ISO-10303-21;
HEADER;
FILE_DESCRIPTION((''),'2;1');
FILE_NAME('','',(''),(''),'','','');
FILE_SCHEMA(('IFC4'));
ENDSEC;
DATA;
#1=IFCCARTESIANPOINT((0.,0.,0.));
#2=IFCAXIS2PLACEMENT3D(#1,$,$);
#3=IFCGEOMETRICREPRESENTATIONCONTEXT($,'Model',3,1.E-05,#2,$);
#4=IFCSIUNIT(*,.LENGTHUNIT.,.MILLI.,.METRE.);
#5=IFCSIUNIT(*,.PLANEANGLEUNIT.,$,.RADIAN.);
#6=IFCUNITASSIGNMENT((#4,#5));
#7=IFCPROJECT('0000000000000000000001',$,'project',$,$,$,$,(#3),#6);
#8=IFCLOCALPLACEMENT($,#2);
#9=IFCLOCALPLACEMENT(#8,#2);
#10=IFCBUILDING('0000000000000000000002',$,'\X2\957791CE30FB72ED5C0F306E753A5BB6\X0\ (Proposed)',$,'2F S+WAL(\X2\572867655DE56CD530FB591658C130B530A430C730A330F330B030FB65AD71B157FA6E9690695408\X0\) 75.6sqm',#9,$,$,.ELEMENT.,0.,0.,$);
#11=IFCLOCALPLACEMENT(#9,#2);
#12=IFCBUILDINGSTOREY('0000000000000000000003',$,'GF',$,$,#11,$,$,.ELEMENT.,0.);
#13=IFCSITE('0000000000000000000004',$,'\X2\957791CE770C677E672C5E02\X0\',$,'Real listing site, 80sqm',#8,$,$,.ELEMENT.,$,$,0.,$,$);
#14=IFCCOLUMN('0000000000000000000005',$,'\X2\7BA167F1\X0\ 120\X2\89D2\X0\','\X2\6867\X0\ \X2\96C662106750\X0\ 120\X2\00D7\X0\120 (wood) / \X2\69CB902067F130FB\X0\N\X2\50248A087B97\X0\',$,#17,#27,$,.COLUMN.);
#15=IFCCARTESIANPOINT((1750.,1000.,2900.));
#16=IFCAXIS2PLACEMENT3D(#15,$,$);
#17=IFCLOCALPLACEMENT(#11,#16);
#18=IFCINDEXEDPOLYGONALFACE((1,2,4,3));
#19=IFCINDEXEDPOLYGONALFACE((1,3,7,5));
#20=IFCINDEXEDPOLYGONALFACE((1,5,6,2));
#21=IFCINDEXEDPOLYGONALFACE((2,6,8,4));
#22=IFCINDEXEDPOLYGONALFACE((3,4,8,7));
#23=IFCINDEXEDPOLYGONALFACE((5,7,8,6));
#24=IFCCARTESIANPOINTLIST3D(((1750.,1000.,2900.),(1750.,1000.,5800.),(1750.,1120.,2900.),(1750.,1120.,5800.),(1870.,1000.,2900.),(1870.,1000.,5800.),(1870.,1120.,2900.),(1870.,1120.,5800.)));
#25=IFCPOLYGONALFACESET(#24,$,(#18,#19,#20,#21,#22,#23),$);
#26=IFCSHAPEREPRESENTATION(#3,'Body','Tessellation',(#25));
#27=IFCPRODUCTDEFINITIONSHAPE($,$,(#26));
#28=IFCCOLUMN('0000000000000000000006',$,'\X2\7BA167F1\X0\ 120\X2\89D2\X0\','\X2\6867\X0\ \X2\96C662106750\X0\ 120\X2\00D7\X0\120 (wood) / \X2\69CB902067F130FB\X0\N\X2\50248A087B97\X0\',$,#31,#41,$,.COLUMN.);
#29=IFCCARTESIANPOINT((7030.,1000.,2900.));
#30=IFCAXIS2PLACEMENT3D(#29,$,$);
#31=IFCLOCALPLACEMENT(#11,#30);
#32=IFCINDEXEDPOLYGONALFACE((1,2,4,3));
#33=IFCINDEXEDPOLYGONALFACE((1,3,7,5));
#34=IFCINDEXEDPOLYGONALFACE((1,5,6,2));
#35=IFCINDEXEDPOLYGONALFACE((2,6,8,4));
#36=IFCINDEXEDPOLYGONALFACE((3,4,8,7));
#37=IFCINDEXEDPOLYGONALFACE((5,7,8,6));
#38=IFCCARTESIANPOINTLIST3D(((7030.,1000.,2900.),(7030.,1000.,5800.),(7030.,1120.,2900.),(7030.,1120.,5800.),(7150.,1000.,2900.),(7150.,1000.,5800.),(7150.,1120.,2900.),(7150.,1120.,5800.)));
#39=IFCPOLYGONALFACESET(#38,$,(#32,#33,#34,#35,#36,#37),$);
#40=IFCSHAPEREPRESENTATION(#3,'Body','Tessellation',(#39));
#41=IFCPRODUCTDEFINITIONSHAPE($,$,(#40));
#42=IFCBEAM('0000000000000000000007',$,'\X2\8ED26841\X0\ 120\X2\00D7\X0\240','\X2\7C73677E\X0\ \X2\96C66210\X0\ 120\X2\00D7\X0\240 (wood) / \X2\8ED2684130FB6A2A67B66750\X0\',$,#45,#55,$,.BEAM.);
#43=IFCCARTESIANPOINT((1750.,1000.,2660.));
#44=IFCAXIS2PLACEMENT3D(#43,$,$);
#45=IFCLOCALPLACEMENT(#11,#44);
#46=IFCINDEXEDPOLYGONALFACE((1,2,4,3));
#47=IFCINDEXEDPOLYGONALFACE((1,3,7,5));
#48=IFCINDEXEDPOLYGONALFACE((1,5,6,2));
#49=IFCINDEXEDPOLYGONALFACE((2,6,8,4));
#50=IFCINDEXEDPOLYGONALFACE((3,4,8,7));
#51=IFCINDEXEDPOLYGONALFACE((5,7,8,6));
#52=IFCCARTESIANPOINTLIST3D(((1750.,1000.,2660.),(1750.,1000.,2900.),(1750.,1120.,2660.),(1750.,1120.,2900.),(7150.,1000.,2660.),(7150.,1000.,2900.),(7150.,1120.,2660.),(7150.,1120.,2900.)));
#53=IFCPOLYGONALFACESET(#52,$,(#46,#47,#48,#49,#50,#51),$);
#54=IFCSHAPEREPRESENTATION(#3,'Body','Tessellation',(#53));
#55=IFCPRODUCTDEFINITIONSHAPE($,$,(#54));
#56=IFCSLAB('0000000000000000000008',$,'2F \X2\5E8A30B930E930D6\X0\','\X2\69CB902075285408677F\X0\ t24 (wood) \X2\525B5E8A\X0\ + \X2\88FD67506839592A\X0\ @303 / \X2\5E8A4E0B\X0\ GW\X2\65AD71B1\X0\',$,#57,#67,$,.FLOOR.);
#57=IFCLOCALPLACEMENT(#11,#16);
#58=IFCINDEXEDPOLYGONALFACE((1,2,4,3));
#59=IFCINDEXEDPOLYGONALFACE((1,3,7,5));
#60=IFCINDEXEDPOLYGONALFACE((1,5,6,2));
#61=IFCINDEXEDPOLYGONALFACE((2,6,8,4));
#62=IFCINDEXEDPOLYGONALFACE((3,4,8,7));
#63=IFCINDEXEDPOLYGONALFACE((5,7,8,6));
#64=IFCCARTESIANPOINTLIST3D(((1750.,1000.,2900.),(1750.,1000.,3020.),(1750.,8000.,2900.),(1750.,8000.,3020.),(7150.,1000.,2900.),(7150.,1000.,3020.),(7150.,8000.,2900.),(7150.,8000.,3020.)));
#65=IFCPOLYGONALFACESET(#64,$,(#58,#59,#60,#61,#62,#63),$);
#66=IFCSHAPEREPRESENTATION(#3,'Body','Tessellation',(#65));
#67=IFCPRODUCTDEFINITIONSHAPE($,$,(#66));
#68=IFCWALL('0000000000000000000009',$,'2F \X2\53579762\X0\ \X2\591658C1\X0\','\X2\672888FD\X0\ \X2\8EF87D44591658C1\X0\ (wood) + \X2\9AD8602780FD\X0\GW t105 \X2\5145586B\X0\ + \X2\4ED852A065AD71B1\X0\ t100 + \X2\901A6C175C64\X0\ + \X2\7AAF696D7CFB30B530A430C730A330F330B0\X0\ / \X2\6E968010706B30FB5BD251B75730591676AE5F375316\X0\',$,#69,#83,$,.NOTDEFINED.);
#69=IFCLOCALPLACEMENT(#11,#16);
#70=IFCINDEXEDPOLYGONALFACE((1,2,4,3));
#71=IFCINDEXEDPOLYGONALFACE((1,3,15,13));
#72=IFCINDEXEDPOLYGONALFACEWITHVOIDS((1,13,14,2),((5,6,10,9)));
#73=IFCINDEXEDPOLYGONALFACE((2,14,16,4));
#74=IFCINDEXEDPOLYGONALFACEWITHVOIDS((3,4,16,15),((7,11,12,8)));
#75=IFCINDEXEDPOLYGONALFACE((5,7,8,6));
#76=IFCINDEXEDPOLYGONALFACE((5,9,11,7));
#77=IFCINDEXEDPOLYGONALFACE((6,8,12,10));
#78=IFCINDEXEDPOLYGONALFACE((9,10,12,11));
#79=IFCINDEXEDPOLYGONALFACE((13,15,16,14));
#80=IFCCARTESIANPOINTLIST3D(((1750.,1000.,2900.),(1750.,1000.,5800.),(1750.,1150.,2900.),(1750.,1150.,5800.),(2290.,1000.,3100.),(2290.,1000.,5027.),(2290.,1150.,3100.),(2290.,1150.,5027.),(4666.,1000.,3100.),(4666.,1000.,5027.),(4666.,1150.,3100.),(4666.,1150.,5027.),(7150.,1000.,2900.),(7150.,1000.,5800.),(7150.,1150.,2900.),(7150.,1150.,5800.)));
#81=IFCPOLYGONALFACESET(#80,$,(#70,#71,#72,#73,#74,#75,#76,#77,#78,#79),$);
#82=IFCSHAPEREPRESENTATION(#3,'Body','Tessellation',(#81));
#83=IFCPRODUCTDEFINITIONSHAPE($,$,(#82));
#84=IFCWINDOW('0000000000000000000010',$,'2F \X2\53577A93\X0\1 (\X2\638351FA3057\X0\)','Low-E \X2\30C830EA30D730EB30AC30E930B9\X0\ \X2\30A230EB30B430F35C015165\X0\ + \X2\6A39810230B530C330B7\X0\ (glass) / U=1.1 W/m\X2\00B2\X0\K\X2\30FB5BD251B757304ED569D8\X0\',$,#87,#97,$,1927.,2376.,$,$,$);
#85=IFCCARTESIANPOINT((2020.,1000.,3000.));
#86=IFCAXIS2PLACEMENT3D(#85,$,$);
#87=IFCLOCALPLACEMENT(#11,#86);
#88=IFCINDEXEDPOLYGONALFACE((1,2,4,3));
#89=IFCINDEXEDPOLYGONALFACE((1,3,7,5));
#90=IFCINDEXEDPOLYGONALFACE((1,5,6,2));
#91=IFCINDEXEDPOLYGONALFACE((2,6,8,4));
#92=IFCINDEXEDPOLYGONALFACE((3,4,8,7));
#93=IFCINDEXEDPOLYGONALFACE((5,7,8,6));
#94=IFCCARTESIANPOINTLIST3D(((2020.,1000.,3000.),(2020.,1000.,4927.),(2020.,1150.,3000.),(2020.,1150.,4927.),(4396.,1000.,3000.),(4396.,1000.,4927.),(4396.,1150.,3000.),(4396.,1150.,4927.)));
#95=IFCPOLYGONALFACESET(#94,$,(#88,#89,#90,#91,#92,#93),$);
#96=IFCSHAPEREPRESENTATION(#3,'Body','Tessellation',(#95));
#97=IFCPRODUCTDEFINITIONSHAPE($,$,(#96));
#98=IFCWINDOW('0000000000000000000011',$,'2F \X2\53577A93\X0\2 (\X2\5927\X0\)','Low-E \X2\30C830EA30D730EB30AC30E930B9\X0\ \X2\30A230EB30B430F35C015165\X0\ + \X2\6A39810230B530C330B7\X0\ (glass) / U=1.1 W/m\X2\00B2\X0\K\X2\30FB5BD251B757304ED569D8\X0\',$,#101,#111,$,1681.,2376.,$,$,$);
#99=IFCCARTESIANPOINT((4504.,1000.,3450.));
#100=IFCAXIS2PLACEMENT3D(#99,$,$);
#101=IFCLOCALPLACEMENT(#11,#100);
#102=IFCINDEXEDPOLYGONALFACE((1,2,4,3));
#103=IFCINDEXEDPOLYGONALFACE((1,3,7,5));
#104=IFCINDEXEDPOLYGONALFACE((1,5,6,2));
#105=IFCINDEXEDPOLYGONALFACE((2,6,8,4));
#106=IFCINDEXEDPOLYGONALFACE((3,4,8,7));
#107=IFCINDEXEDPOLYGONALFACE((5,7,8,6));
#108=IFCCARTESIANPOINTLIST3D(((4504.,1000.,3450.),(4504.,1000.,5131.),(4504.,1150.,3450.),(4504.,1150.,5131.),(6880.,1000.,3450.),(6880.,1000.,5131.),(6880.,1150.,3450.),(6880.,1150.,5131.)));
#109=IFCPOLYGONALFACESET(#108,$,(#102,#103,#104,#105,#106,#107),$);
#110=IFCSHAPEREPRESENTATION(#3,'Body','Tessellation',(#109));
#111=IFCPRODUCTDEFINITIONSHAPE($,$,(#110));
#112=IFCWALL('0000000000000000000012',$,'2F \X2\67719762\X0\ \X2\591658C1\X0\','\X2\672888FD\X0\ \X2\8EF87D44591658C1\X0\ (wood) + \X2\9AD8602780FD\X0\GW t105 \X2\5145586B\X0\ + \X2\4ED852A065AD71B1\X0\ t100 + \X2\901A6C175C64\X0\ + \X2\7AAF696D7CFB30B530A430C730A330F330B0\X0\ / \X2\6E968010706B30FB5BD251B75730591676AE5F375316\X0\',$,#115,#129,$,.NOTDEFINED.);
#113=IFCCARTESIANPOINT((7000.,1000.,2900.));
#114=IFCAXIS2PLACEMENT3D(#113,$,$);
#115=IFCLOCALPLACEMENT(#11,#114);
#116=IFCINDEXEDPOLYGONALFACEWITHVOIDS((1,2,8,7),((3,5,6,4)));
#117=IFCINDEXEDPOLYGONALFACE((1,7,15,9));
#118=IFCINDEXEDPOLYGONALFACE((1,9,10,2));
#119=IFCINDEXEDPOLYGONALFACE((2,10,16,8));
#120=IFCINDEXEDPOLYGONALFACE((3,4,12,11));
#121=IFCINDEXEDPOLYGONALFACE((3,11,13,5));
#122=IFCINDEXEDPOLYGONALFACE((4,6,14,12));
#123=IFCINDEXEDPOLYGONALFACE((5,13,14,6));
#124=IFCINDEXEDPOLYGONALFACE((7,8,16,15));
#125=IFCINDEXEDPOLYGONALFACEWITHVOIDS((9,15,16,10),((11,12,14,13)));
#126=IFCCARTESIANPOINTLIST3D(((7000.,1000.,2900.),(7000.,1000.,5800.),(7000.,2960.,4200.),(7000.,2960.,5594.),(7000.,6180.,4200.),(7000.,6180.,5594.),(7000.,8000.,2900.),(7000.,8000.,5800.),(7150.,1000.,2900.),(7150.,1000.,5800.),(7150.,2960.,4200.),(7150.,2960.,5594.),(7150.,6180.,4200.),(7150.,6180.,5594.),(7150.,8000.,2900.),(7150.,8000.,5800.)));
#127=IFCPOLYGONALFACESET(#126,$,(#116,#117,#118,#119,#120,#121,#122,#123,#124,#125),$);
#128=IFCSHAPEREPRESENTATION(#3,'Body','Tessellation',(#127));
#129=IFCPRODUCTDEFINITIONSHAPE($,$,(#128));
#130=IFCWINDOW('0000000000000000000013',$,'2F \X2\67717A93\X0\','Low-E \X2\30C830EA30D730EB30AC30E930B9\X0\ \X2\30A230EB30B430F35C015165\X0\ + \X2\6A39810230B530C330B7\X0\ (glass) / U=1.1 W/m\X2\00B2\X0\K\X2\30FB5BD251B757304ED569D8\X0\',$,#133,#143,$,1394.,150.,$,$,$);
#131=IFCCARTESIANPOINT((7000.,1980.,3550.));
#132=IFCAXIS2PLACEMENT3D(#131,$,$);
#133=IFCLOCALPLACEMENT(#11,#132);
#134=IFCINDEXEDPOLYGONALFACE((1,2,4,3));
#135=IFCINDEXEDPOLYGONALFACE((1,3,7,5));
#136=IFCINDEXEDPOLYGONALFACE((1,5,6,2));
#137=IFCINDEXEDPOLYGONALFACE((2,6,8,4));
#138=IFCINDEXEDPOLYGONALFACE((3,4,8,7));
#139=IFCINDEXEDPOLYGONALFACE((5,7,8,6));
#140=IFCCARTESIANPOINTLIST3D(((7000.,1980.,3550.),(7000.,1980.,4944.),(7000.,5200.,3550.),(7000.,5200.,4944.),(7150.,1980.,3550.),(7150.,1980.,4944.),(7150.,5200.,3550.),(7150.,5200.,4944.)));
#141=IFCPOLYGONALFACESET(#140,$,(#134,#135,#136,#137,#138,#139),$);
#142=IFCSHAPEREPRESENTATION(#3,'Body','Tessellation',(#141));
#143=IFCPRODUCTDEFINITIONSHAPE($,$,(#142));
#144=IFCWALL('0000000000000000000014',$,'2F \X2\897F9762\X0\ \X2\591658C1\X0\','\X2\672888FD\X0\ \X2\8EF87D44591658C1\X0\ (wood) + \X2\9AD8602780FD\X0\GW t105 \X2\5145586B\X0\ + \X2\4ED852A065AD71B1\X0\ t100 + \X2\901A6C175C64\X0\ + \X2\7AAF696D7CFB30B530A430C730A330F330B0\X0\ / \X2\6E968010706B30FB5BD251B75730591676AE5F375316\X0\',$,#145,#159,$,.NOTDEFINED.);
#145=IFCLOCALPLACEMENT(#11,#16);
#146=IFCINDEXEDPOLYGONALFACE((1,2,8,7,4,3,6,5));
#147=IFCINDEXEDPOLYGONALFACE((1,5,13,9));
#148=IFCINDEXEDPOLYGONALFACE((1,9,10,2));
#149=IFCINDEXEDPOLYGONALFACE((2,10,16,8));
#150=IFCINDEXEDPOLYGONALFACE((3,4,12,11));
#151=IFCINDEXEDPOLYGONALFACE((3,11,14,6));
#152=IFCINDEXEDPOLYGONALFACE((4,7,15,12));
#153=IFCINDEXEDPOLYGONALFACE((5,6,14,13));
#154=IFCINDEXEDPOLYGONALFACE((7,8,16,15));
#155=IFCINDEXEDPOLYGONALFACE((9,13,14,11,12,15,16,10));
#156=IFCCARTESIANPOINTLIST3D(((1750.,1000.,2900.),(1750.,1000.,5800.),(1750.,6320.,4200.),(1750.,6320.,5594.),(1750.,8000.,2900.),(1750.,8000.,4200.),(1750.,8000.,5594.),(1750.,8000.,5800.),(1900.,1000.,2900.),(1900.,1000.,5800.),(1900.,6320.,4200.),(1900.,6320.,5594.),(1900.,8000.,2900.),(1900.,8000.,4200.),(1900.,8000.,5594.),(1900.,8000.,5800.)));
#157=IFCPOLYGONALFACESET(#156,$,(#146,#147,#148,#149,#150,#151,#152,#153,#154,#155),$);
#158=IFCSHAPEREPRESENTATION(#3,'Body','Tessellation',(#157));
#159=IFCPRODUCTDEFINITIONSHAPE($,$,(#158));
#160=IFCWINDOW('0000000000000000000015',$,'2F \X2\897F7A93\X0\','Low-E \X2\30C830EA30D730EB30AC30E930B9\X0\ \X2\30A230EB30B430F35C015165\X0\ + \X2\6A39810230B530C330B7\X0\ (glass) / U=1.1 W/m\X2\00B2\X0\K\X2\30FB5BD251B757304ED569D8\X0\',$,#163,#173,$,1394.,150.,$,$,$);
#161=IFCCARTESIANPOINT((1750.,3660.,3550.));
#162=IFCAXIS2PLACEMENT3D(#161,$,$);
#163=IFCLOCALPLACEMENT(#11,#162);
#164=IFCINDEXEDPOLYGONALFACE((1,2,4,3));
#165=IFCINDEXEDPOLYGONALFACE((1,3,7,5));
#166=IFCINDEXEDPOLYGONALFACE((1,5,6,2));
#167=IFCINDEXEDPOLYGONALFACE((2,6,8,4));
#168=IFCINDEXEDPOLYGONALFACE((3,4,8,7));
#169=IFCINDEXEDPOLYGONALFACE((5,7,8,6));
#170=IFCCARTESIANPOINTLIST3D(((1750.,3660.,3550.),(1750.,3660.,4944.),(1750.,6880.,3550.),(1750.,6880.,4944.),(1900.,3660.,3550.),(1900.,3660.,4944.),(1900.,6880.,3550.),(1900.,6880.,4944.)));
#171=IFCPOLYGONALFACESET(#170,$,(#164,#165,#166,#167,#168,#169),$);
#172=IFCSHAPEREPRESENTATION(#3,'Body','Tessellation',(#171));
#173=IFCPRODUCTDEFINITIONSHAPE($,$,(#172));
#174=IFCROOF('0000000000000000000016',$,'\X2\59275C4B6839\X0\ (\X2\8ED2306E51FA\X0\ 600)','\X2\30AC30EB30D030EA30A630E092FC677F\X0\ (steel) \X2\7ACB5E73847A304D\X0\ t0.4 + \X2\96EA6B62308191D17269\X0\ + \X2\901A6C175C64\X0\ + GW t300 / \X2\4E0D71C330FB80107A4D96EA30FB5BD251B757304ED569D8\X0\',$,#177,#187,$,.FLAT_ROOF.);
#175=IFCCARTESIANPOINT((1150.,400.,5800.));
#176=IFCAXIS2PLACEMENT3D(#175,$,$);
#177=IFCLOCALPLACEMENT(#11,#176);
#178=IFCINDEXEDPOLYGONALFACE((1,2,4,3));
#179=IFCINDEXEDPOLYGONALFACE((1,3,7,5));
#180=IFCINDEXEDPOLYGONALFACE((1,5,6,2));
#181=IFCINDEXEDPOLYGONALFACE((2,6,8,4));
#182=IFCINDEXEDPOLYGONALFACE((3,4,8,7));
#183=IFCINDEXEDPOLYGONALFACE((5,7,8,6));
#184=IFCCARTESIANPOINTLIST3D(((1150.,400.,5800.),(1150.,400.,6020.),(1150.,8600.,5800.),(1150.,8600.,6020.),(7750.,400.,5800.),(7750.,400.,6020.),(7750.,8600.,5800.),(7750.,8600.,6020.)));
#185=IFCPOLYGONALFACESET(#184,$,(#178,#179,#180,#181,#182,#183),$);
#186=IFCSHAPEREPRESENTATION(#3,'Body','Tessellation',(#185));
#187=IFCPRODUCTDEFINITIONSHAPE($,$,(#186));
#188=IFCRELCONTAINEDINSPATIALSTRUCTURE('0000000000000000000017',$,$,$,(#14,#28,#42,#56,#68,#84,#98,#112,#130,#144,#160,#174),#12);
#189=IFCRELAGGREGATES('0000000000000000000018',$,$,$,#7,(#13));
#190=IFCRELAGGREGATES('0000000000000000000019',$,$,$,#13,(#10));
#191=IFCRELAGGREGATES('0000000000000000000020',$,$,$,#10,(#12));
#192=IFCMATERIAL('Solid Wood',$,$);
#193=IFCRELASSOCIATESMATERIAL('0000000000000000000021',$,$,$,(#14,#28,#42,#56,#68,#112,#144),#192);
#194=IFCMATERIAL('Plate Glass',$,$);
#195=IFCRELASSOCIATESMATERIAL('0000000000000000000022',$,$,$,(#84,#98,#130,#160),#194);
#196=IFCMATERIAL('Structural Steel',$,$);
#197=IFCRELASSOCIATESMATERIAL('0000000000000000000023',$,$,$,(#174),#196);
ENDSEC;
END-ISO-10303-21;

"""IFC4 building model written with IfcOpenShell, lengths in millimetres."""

from ifc_helpers import new_model, si_unit, frame, frame_2d, origin, place, context, project, spatial, rectangle, extrude, material, element, fill, save


model = new_model("IFC4")

# Units and contexts
model_context = context("Model", 3, precision=1e-05, world=origin())
ifc_project = project(units=[si_unit("LENGTHUNIT", "METRE", prefix="MILLI"), si_unit("PLANEANGLEUNIT", "RADIAN")], contexts=[model_context])

# Site, building, storey
site_placement = place(None, origin())
site = spatial("IfcSite", under=ifc_project, at=site_placement, Name="長野県松本市", ObjectType="Real listing site, 80sqm", CompositionType="ELEMENT", RefElevation=0.0)
building_placement = place(site_placement, origin())
building = spatial("IfcBuilding", under=site, at=building_placement, Name="長野・狭小の町家 (Proposed)", ObjectType="2F S+WAL(在来工法・外壁サイディング・断熱基準適合) 75.6sqm", CompositionType="ELEMENT", ElevationOfRefHeight=0.0, ElevationOfTerrain=0.0)
storey_placement = place(building_placement, origin())
storey = spatial("IfcBuildingStorey", under=building, at=storey_placement, Name="GF", CompositionType="ELEMENT", Elevation=0.0)

# Columns
ifc_material_1 = material(Name="Solid Wood")
column_1_placement = place(storey_placement, frame((1750.0, 1000.0, 2900.0)))
element("IfcColumn", 1, at=column_1_placement, inside=storey, material=ifc_material_1, Name="管柱 120角", Description="桧 集成材 120×120 (wood) / 構造柱・N値計算", PredefinedType="COLUMN", context=model_context, shape_type="SweptSolid", body=[
    extrude(rectangle(XDim=120.0, YDim=120.0, at=frame_2d((60.0, 60.0))), frame((1750.0, 1000.0, 2900.0)), (0.0, 0.0, 1.0), 2900.0),
])
column_2_placement = place(storey_placement, frame((7030.0, 1000.0, 2900.0)))
element("IfcColumn", 2, at=column_2_placement, inside=storey, material=ifc_material_1, Name="管柱 120角", Description="桧 集成材 120×120 (wood) / 構造柱・N値計算", PredefinedType="COLUMN", context=model_context, shape_type="SweptSolid", body=[
    extrude(rectangle(XDim=120.0, YDim=120.0, at=frame_2d((60.0, 60.0))), frame((7030.0, 1000.0, 2900.0)), (0.0, 0.0, 1.0), 2900.0),
])

# Beam
beam_1_placement = place(storey_placement, frame((1750.0, 1000.0, 2660.0)))
element("IfcBeam", 3, at=beam_1_placement, inside=storey, material=ifc_material_1, Name="軒桁 120×240", Description="米松 集成 120×240 (wood) / 軒桁・横架材", PredefinedType="BEAM", context=model_context, shape_type="SweptSolid", body=[
    extrude(rectangle(XDim=5400.0, YDim=120.0, at=frame_2d((2700.0, 60.0))), frame((1750.0, 1000.0, 2660.0)), (0.0, 0.0, 1.0), 240.0),
])

# Slab
slab_placement = place(storey_placement, frame((1750.0, 1000.0, 2900.0)))
element("IfcSlab", 4, at=slab_placement, inside=storey, material=ifc_material_1, Name="2F 床スラブ", Description="構造用合板 t24 (wood) 剛床 + 製材根太 @303 / 床下 GW断熱", PredefinedType="FLOOR", context=model_context, shape_type="SweptSolid", body=[
    extrude(rectangle(XDim=5400.0, YDim=7000.0, at=frame_2d((2700.0, 3500.0))), frame((1750.0, 1000.0, 2900.0)), (0.0, 0.0, 1.0), 120.0),
])

# Wall, openings, windows
wall_1_placement = place(storey_placement, frame((1750.0, 1000.0, 2900.0)))
wall_1 = element("IfcWall", 5, at=wall_1_placement, inside=storey, material=ifc_material_1, Name="2F 南面 外壁", Description="木製 軸組外壁 (wood) + 高性能GW t105 充填 + 付加断熱 t100 + 通気層 + 窯業系サイディング / 準耐火・寒冷地外皮強化", PredefinedType="NOTDEFINED", context=model_context, shape_type="SweptSolid", body=[
    extrude(rectangle(XDim=5400.0, YDim=150.0, at=frame_2d((2700.0, 75.0))), frame((1750.0, 1000.0, 2900.0)), (0.0, 0.0, 1.0), 2900.0),
])
opening_1_placement = place(storey_placement, frame((2020.0, 1000.0, 3000.0)))
opening_1 = element("IfcOpeningElement", 6, at=opening_1_placement, cuts=wall_1, PredefinedType="NOTDEFINED", context=model_context, shape_type="SweptSolid", body=[
    extrude(rectangle(XDim=2376.0, YDim=150.0, at=frame_2d((1188.0, 75.0))), frame((2020.0, 1000.0, 3000.0)), (0.0, 0.0, 1.0), 1927.0),
])
opening_2_placement = place(storey_placement, frame((4504.0, 1000.0, 3450.0)))
opening_2 = element("IfcOpeningElement", 7, at=opening_2_placement, cuts=wall_1, PredefinedType="NOTDEFINED", context=model_context, shape_type="SweptSolid", body=[
    extrude(rectangle(XDim=2376.0, YDim=150.0, at=frame_2d((1188.0, 75.0))), frame((4504.0, 1000.0, 3450.0)), (0.0, 0.0, 1.0), 1681.0),
])
ifc_material_2 = material(Name="Plate Glass")
window_1_placement = place(storey_placement, frame((2020.0, 1000.0, 3000.0)))
window_1 = element("IfcWindow", 8, at=window_1_placement, inside=storey, material=ifc_material_2, Name="2F 南窓1 (掃出し)", Description="Low-E トリプルガラス アルゴン封入 + 樹脂サッシ (glass) / U=1.1 W/m²K・寒冷地仕様", OverallHeight=1927.0, OverallWidth=2376.0, context=model_context, shape_type="SweptSolid", body=[
    extrude(rectangle(XDim=2376.0, YDim=150.0, at=frame_2d((1188.0, 75.0))), frame((2020.0, 1000.0, 3000.0)), (0.0, 0.0, 1.0), 1927.0),
])
fill(opening_1, window_1)
window_2_placement = place(storey_placement, frame((4504.0, 1000.0, 3450.0)))
window_2 = element("IfcWindow", 9, at=window_2_placement, inside=storey, material=ifc_material_2, Name="2F 南窓2 (大)", Description="Low-E トリプルガラス アルゴン封入 + 樹脂サッシ (glass) / U=1.1 W/m²K・寒冷地仕様", OverallHeight=1681.0, OverallWidth=2376.0, context=model_context, shape_type="SweptSolid", body=[
    extrude(rectangle(XDim=2376.0, YDim=150.0, at=frame_2d((1188.0, 75.0))), frame((4504.0, 1000.0, 3450.0)), (0.0, 0.0, 1.0), 1681.0),
])
fill(opening_2, window_2)

# Walls, openings, windows
wall_2_placement = place(storey_placement, frame((7000.0, 1000.0, 2900.0)))
wall_2 = element("IfcWall", 10, at=wall_2_placement, inside=storey, material=ifc_material_1, Name="2F 東面 外壁", Description="木製 軸組外壁 (wood) + 高性能GW t105 充填 + 付加断熱 t100 + 通気層 + 窯業系サイディング / 準耐火・寒冷地外皮強化", PredefinedType="NOTDEFINED", context=model_context, shape_type="SweptSolid", body=[
    extrude(rectangle(XDim=150.0, YDim=7000.0, at=frame_2d((75.0, 3500.0))), frame((7000.0, 1000.0, 2900.0)), (0.0, 0.0, 1.0), 2900.0),
])
opening_3_placement = place(storey_placement, frame((7000.0, 1980.0, 3550.0)))
opening_3 = element("IfcOpeningElement", 11, at=opening_3_placement, cuts=wall_2, PredefinedType="NOTDEFINED", context=model_context, shape_type="SweptSolid", body=[
    extrude(rectangle(XDim=150.0, YDim=3220.0, at=frame_2d((75.0, 1610.0))), frame((7000.0, 1980.0, 3550.0)), (0.0, 0.0, 1.0), 1394.0),
])
window_3_placement = place(storey_placement, frame((7000.0, 1980.0, 3550.0)))
window_3 = element("IfcWindow", 12, at=window_3_placement, inside=storey, material=ifc_material_2, Name="2F 東窓", Description="Low-E トリプルガラス アルゴン封入 + 樹脂サッシ (glass) / U=1.1 W/m²K・寒冷地仕様", OverallHeight=1394.0, OverallWidth=150.0, context=model_context, shape_type="SweptSolid", body=[
    extrude(rectangle(XDim=150.0, YDim=3220.0, at=frame_2d((75.0, 1610.0))), frame((7000.0, 1980.0, 3550.0)), (0.0, 0.0, 1.0), 1394.0),
])
fill(opening_3, window_3)
wall_3_placement = place(storey_placement, frame((1750.0, 1000.0, 2900.0)))
wall_3 = element("IfcWall", 13, at=wall_3_placement, inside=storey, material=ifc_material_1, Name="2F 西面 外壁", Description="木製 軸組外壁 (wood) + 高性能GW t105 充填 + 付加断熱 t100 + 通気層 + 窯業系サイディング / 準耐火・寒冷地外皮強化", PredefinedType="NOTDEFINED", context=model_context, shape_type="SweptSolid", body=[
    extrude(rectangle(XDim=150.0, YDim=7000.0, at=frame_2d((75.0, 3500.0))), frame((1750.0, 1000.0, 2900.0)), (0.0, 0.0, 1.0), 2900.0),
])
opening_4_placement = place(storey_placement, frame((1750.0, 3660.0, 3550.0)))
opening_4 = element("IfcOpeningElement", 14, at=opening_4_placement, cuts=wall_3, PredefinedType="NOTDEFINED", context=model_context, shape_type="SweptSolid", body=[
    extrude(rectangle(XDim=150.0, YDim=3220.0, at=frame_2d((75.0, 1610.0))), frame((1750.0, 3660.0, 3550.0)), (0.0, 0.0, 1.0), 1394.0),
])
window_4_placement = place(storey_placement, frame((1750.0, 3660.0, 3550.0)))
window_4 = element("IfcWindow", 15, at=window_4_placement, inside=storey, material=ifc_material_2, Name="2F 西窓", Description="Low-E トリプルガラス アルゴン封入 + 樹脂サッシ (glass) / U=1.1 W/m²K・寒冷地仕様", OverallHeight=1394.0, OverallWidth=150.0, context=model_context, shape_type="SweptSolid", body=[
    extrude(rectangle(XDim=150.0, YDim=3220.0, at=frame_2d((75.0, 1610.0))), frame((1750.0, 3660.0, 3550.0)), (0.0, 0.0, 1.0), 1394.0),
])
fill(opening_4, window_4)

# Roof
ifc_material_3 = material(Name="Structural Steel")
roof_placement = place(storey_placement, frame((1150.0, 400.0, 5800.0)))
element("IfcRoof", 16, at=roof_placement, inside=storey, material=ifc_material_3, Name="大屋根 (軒の出 600)", Description="ガルバリウム鋼板 (steel) 立平葺き t0.4 + 雪止め金物 + 通気層 + GW t300 / 不燃・耐積雪・寒冷地仕様", PredefinedType="FLAT_ROOF", context=model_context, shape_type="SweptSolid", body=[
    extrude(rectangle(XDim=6600.0, YDim=8200.0, at=frame_2d((3300.0, 4100.0))), frame((1150.0, 400.0, 5800.0)), (0.0, 0.0, 1.0), 220.0),
])

save(model, "model.ifc")
